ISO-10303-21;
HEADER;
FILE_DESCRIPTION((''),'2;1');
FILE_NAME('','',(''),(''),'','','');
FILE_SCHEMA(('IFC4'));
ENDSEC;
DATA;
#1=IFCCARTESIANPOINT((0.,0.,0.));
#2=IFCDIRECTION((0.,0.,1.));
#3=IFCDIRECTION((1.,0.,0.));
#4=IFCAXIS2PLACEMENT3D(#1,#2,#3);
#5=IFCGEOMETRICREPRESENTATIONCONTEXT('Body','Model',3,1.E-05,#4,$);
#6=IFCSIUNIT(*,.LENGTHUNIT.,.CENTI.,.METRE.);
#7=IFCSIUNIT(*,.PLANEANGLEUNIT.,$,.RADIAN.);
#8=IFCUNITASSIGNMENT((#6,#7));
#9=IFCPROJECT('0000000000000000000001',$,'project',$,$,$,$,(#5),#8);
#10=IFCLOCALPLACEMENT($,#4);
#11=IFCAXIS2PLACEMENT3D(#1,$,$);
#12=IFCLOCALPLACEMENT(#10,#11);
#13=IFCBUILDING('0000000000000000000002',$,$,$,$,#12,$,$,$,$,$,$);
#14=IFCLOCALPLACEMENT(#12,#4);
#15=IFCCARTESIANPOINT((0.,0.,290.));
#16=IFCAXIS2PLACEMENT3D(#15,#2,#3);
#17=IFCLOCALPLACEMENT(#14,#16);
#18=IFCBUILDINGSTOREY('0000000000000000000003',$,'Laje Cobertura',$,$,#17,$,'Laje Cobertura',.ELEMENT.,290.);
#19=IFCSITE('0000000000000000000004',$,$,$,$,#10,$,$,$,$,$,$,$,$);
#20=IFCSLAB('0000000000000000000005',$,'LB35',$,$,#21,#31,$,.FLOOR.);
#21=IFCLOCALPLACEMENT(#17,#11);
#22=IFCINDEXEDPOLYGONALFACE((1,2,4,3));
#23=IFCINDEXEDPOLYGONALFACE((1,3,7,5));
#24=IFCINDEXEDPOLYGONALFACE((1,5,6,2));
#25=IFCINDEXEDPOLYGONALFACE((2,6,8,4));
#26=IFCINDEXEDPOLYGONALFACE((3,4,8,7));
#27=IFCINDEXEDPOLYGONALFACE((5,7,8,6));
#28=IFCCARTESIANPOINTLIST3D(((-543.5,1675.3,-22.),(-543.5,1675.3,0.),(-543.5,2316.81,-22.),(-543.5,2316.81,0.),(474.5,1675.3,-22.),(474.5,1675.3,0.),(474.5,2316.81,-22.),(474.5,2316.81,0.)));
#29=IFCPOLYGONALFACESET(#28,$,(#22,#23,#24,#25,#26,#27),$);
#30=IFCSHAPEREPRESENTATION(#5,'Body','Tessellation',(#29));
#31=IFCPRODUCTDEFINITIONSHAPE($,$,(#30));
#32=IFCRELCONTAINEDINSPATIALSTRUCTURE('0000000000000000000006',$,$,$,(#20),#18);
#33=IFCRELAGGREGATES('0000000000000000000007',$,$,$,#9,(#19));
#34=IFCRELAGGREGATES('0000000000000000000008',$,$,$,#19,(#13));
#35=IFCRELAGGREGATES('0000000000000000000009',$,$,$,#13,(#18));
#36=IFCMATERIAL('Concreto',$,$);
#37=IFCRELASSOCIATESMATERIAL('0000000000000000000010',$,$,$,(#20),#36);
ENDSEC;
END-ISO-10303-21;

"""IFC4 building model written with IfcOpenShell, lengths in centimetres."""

from ifc_helpers import new_model, si_unit, frame, origin, origin_with_axes, place, context, project, spatial, polyline, outline, extrude, material, element, save


model = new_model("IFC4")

# Units and contexts
model_context = context("Model", 3, precision=1e-05, world=origin_with_axes(), identifier="Body")
ifc_project = project(units=[si_unit("LENGTHUNIT", "METRE", prefix="CENTI"), si_unit("PLANEANGLEUNIT", "RADIAN")], contexts=[model_context])

# Site, building, storey
site_placement = place(None, origin_with_axes())
site = spatial("IfcSite", under=ifc_project, at=site_placement)
building_placement = place(site_placement, origin())
building = spatial("IfcBuilding", under=site, at=building_placement)
placement = place(building_placement, origin_with_axes())
storey_placement = place(placement, frame((0.0, 0.0, 290.0), z_axis=(0.0, 0.0, 1.0), x_axis=(1.0, 0.0, 0.0)))
storey = spatial("IfcBuildingStorey", under=building, at=storey_placement, Name="Laje Cobertura", LongName="Laje Cobertura", CompositionType="ELEMENT", Elevation=290.0)

# Shared definitions
ifc_material = material(Name="Concreto")

# Slab
slab_1_placement = place(storey_placement, frame((-34.5, 1996.06, 0.0), z_axis=(0.0, 0.0, 1.0), x_axis=(1.0, 0.0, 0.0)))
element("IfcSlab", 1, at=slab_1_placement, inside=storey, material=ifc_material, Name="LB35", PredefinedType="FLOOR", context=model_context, shape_type="SolidModel", body=[
    extrude(outline(polyline([(509.0, 320.75), (-509.0, 320.75), (-509.0, -320.75), (509.0, -320.75), (509.0, 320.75), (509.0, 320.75)])), frame((0.0, 0.0, -22.0), z_axis=(0.0, 0.0, 1.0), x_axis=(1.0, 0.0, 0.0)), (0.0, 0.0, 1.0), 22.0),
])

save(model, "model.ifc")
